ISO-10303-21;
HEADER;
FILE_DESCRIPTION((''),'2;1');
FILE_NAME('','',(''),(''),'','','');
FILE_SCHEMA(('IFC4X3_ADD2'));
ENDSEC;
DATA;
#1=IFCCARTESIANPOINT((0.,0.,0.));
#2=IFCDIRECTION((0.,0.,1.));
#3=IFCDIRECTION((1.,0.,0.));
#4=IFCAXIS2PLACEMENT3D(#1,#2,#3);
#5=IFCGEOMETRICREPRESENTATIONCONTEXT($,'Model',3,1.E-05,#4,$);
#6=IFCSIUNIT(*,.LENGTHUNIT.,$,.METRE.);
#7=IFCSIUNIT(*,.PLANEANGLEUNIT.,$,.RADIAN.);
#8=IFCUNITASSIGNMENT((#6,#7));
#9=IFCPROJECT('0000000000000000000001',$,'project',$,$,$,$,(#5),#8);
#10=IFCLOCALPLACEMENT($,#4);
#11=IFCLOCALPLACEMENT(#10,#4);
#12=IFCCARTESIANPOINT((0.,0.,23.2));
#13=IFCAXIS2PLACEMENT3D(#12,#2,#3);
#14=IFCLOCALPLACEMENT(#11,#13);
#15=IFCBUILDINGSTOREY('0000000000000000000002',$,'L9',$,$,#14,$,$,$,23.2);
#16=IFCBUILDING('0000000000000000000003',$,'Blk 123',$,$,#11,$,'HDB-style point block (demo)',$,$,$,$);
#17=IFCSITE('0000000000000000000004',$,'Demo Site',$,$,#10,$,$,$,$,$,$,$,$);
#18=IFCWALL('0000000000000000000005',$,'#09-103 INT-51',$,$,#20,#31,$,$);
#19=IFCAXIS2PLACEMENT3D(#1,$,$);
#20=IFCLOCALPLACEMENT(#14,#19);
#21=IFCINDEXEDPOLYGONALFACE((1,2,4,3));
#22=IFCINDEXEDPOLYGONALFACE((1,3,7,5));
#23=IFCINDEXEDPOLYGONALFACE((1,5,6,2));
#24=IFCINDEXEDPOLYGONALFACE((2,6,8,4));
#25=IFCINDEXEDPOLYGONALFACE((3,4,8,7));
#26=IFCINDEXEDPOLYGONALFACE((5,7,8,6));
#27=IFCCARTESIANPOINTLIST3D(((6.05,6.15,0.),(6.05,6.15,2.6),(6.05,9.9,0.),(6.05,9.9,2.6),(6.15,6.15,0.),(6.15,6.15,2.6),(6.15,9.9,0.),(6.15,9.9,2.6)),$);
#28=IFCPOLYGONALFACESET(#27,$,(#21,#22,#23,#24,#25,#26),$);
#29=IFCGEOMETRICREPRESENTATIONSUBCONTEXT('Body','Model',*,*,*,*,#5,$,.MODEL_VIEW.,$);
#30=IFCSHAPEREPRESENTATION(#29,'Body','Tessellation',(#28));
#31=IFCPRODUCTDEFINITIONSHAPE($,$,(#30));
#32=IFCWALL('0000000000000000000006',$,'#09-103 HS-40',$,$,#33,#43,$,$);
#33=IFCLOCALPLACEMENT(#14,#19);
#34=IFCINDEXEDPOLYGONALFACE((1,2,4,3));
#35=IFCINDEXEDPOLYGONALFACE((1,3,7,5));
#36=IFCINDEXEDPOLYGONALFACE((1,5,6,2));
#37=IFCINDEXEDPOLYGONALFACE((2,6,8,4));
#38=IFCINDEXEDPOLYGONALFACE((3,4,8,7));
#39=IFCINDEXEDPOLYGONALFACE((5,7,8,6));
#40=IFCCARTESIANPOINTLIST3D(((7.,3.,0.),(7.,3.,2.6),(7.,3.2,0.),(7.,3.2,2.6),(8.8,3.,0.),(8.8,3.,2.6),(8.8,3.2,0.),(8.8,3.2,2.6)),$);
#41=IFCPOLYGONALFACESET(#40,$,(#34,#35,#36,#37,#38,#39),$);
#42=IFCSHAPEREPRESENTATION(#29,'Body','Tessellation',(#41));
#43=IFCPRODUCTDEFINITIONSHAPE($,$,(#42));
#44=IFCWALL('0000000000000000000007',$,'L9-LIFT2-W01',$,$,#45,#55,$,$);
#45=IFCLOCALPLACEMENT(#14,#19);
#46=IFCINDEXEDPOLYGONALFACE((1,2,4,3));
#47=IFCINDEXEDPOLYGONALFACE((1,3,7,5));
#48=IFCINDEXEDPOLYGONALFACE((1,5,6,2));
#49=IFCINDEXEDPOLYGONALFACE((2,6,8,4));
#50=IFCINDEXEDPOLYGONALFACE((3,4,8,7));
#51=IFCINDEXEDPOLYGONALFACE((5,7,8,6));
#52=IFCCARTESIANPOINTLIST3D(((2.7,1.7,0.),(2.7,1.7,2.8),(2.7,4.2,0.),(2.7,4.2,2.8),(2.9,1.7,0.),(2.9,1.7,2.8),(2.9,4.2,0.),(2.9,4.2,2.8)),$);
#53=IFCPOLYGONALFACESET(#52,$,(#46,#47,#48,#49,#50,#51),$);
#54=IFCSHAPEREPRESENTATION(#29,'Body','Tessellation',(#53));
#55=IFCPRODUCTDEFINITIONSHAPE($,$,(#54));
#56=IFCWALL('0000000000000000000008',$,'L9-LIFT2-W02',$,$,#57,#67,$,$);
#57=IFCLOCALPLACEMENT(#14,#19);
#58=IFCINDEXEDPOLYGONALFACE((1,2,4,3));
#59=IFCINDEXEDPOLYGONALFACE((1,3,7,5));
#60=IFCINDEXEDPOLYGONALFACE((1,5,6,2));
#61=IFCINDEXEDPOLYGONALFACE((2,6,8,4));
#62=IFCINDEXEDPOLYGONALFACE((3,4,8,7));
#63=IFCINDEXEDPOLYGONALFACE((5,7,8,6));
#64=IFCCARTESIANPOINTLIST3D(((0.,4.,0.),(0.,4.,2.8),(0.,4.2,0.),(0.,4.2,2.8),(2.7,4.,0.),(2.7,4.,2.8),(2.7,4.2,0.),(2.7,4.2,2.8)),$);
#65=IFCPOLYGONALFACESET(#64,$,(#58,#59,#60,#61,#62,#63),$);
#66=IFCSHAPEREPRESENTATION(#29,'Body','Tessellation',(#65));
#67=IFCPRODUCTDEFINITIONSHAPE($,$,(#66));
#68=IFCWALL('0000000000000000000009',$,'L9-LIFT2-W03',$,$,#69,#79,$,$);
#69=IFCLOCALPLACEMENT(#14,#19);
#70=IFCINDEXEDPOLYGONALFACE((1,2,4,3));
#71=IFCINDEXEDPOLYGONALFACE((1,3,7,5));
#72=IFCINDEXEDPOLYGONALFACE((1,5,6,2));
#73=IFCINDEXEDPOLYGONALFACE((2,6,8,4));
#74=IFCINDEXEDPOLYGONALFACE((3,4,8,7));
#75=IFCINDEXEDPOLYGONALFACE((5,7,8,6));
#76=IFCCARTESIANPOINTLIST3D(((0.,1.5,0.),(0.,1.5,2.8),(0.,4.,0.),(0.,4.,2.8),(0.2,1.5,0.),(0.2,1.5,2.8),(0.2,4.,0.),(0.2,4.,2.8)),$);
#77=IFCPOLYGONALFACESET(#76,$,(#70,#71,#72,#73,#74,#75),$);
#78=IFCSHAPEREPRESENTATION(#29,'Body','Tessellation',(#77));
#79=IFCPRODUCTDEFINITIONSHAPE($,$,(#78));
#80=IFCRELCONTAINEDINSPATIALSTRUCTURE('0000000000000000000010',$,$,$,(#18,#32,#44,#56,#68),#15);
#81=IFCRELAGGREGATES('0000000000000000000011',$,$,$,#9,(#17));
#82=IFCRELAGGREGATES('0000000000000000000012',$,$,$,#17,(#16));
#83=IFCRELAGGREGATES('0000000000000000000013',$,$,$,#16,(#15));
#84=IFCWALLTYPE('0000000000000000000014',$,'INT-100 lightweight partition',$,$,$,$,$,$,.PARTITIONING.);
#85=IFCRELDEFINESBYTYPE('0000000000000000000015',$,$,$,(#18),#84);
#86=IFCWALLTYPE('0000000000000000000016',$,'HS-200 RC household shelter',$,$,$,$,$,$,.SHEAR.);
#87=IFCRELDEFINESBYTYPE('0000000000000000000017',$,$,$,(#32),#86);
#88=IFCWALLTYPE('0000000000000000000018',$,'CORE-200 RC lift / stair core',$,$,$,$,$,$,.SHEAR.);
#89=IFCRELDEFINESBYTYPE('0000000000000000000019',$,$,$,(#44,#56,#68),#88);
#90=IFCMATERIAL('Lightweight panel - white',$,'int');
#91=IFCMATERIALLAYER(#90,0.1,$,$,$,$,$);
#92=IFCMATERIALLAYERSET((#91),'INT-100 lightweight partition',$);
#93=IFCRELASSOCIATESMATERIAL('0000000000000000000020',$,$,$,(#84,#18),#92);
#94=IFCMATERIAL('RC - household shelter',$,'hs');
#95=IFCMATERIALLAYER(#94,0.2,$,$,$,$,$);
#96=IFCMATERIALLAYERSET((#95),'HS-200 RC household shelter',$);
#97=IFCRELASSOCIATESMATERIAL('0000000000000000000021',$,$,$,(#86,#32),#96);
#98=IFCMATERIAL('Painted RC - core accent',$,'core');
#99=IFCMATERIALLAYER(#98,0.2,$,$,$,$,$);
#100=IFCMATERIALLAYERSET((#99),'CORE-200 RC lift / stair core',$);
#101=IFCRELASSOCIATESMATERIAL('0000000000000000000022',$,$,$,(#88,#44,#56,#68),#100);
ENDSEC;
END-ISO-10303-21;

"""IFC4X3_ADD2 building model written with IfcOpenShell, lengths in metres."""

from ifc_helpers import new_model, si_unit, frame, origin_with_axes, place, context, subcontext, project, spatial, indexed_curve, outline, extrude, material, layer, layer_set, layer_usage, type_object, element, save


model = new_model("IFC4X3_ADD2")

# Units and contexts
model_context = context("Model", 3, precision=1e-05, world=origin_with_axes())
body_context = subcontext(model_context, "Body", "Model", "MODEL_VIEW")
ifc_project = project(units=[si_unit("LENGTHUNIT", "METRE"), si_unit("PLANEANGLEUNIT", "RADIAN")], contexts=[model_context])

# Site, building, storey
site_placement = place(None, origin_with_axes())
site = spatial("IfcSite", under=ifc_project, at=site_placement, Name="Demo Site")
building_placement = place(site_placement, origin_with_axes())
building = spatial("IfcBuilding", under=site, at=building_placement, Name="Blk 123", LongName="HDB-style point block (demo)")
storey_placement = place(building_placement, frame((0.0, 0.0, 23.2), z_axis=(0.0, 0.0, 1.0), x_axis=(1.0, 0.0, 0.0)))
storey = spatial("IfcBuildingStorey", under=building, at=storey_placement, Name="L9", Elevation=23.2)

# Shared definitions
ifc_material_1 = material(Name="Lightweight panel - white", Category="int")
ifc_layer_1 = layer(ifc_material_1, 0.1)
ifc_layer_set_1 = layer_set([ifc_layer_1], Name="INT-100 lightweight partition")
ifc_layer_usage_1 = layer_usage(ifc_layer_set_1, "AXIS2", "POSITIVE", -0.05)
wall_type_1 = type_object("IfcWallType", Name="INT-100 lightweight partition", PredefinedType="PARTITIONING", material=ifc_layer_set_1)

# Walls
wall_1_placement = place(storey_placement, frame((6.1, 6.15, 0.0), z_axis=(0.0, 0.0, 1.0), x_axis=(0.0, 1.0, 0.0)))
element("IfcWall", 1, at=wall_1_placement, inside=storey, type_object=wall_type_1, material=ifc_layer_usage_1, Name="#09-103 INT-51", context=body_context, shape_type="SweptSolid", body=[
    extrude(outline(indexed_curve([(0.0, 0.0), (0.0, 0.1), (3.75, 0.1), (3.75, 0.0), (0.0, 0.0)], self_intersect=False)), frame((0.0, -0.05, 0.0), z_axis=(0.0, 0.0, 1.0), x_axis=(1.0, 0.0, 0.0)), (0.0, 0.0, 1.0), 2.6),
])
ifc_material_2 = material(Name="RC - household shelter", Category="hs")
ifc_layer_2 = layer(ifc_material_2, 0.2)
ifc_layer_set_2 = layer_set([ifc_layer_2], Name="HS-200 RC household shelter")
ifc_layer_usage_2 = layer_usage(ifc_layer_set_2, "AXIS2", "POSITIVE", -0.1)
wall_type_2 = type_object("IfcWallType", Name="HS-200 RC household shelter", PredefinedType="SHEAR", material=ifc_layer_set_2)
wall_2_placement = place(storey_placement, frame((7.0, 3.1, 0.0), z_axis=(0.0, 0.0, 1.0), x_axis=(1.0, 0.0, 0.0)))
element("IfcWall", 2, at=wall_2_placement, inside=storey, type_object=wall_type_2, material=ifc_layer_usage_2, Name="#09-103 HS-40", context=body_context, shape_type="SweptSolid", body=[
    extrude(outline(indexed_curve([(0.0, 0.0), (0.0, 0.2), (1.8, 0.2), (1.8, 0.0), (0.0, 0.0)], self_intersect=False)), frame((0.0, -0.1, 0.0), z_axis=(0.0, 0.0, 1.0), x_axis=(1.0, 0.0, 0.0)), (0.0, 0.0, 1.0), 2.6),
])
ifc_material_3 = material(Name="Painted RC - core accent", Category="core")
ifc_layer_3 = layer(ifc_material_3, 0.2)
ifc_layer_set_3 = layer_set([ifc_layer_3], Name="CORE-200 RC lift / stair core")
ifc_layer_usage_3 = layer_usage(ifc_layer_set_3, "AXIS2", "POSITIVE", 0.0)
wall_type_3 = type_object("IfcWallType", Name="CORE-200 RC lift / stair core", PredefinedType="SHEAR", material=ifc_layer_set_3)
wall_3_placement = place(storey_placement, frame((2.9, 1.7, 0.0), z_axis=(0.0, 0.0, 1.0), x_axis=(0.0, 1.0, 0.0)))
element("IfcWall", 3, at=wall_3_placement, inside=storey, type_object=wall_type_3, material=ifc_layer_usage_3, Name="L9-LIFT2-W01", context=body_context, shape_type="SweptSolid", body=[
    extrude(outline(indexed_curve([(0.0, 0.0), (0.0, 0.2), (2.5, 0.2), (2.5, 0.0), (0.0, 0.0)], self_intersect=False)), origin_with_axes(), (0.0, 0.0, 1.0), 2.8),
])
wall_4_placement = place(storey_placement, frame((2.7, 4.2, 0.0), z_axis=(0.0, 0.0, 1.0), x_axis=(-1.0, 0.0, 0.0)))
element("IfcWall", 4, at=wall_4_placement, inside=storey, type_object=wall_type_3, material=ifc_layer_usage_3, Name="L9-LIFT2-W02", context=body_context, shape_type="SweptSolid", body=[
    extrude(outline(indexed_curve([(0.0, 0.0), (0.0, 0.2), (2.7, 0.2), (2.7, 0.0), (0.0, 0.0)], self_intersect=False)), origin_with_axes(), (0.0, 0.0, 1.0), 2.8),
])
wall_5_placement = place(storey_placement, frame((0.0, 4.0, 0.0), z_axis=(0.0, 0.0, 1.0), x_axis=(0.0, -1.0, 0.0)))
element("IfcWall", 5, at=wall_5_placement, inside=storey, type_object=wall_type_3, material=ifc_layer_usage_3, Name="L9-LIFT2-W03", context=body_context, shape_type="SweptSolid", body=[
    extrude(outline(indexed_curve([(0.0, 0.0), (0.0, 0.2), (2.5, 0.2), (2.5, 0.0), (0.0, 0.0)], self_intersect=False)), origin_with_axes(), (0.0, 0.0, 1.0), 2.8),
])

save(model, "model.ifc")
